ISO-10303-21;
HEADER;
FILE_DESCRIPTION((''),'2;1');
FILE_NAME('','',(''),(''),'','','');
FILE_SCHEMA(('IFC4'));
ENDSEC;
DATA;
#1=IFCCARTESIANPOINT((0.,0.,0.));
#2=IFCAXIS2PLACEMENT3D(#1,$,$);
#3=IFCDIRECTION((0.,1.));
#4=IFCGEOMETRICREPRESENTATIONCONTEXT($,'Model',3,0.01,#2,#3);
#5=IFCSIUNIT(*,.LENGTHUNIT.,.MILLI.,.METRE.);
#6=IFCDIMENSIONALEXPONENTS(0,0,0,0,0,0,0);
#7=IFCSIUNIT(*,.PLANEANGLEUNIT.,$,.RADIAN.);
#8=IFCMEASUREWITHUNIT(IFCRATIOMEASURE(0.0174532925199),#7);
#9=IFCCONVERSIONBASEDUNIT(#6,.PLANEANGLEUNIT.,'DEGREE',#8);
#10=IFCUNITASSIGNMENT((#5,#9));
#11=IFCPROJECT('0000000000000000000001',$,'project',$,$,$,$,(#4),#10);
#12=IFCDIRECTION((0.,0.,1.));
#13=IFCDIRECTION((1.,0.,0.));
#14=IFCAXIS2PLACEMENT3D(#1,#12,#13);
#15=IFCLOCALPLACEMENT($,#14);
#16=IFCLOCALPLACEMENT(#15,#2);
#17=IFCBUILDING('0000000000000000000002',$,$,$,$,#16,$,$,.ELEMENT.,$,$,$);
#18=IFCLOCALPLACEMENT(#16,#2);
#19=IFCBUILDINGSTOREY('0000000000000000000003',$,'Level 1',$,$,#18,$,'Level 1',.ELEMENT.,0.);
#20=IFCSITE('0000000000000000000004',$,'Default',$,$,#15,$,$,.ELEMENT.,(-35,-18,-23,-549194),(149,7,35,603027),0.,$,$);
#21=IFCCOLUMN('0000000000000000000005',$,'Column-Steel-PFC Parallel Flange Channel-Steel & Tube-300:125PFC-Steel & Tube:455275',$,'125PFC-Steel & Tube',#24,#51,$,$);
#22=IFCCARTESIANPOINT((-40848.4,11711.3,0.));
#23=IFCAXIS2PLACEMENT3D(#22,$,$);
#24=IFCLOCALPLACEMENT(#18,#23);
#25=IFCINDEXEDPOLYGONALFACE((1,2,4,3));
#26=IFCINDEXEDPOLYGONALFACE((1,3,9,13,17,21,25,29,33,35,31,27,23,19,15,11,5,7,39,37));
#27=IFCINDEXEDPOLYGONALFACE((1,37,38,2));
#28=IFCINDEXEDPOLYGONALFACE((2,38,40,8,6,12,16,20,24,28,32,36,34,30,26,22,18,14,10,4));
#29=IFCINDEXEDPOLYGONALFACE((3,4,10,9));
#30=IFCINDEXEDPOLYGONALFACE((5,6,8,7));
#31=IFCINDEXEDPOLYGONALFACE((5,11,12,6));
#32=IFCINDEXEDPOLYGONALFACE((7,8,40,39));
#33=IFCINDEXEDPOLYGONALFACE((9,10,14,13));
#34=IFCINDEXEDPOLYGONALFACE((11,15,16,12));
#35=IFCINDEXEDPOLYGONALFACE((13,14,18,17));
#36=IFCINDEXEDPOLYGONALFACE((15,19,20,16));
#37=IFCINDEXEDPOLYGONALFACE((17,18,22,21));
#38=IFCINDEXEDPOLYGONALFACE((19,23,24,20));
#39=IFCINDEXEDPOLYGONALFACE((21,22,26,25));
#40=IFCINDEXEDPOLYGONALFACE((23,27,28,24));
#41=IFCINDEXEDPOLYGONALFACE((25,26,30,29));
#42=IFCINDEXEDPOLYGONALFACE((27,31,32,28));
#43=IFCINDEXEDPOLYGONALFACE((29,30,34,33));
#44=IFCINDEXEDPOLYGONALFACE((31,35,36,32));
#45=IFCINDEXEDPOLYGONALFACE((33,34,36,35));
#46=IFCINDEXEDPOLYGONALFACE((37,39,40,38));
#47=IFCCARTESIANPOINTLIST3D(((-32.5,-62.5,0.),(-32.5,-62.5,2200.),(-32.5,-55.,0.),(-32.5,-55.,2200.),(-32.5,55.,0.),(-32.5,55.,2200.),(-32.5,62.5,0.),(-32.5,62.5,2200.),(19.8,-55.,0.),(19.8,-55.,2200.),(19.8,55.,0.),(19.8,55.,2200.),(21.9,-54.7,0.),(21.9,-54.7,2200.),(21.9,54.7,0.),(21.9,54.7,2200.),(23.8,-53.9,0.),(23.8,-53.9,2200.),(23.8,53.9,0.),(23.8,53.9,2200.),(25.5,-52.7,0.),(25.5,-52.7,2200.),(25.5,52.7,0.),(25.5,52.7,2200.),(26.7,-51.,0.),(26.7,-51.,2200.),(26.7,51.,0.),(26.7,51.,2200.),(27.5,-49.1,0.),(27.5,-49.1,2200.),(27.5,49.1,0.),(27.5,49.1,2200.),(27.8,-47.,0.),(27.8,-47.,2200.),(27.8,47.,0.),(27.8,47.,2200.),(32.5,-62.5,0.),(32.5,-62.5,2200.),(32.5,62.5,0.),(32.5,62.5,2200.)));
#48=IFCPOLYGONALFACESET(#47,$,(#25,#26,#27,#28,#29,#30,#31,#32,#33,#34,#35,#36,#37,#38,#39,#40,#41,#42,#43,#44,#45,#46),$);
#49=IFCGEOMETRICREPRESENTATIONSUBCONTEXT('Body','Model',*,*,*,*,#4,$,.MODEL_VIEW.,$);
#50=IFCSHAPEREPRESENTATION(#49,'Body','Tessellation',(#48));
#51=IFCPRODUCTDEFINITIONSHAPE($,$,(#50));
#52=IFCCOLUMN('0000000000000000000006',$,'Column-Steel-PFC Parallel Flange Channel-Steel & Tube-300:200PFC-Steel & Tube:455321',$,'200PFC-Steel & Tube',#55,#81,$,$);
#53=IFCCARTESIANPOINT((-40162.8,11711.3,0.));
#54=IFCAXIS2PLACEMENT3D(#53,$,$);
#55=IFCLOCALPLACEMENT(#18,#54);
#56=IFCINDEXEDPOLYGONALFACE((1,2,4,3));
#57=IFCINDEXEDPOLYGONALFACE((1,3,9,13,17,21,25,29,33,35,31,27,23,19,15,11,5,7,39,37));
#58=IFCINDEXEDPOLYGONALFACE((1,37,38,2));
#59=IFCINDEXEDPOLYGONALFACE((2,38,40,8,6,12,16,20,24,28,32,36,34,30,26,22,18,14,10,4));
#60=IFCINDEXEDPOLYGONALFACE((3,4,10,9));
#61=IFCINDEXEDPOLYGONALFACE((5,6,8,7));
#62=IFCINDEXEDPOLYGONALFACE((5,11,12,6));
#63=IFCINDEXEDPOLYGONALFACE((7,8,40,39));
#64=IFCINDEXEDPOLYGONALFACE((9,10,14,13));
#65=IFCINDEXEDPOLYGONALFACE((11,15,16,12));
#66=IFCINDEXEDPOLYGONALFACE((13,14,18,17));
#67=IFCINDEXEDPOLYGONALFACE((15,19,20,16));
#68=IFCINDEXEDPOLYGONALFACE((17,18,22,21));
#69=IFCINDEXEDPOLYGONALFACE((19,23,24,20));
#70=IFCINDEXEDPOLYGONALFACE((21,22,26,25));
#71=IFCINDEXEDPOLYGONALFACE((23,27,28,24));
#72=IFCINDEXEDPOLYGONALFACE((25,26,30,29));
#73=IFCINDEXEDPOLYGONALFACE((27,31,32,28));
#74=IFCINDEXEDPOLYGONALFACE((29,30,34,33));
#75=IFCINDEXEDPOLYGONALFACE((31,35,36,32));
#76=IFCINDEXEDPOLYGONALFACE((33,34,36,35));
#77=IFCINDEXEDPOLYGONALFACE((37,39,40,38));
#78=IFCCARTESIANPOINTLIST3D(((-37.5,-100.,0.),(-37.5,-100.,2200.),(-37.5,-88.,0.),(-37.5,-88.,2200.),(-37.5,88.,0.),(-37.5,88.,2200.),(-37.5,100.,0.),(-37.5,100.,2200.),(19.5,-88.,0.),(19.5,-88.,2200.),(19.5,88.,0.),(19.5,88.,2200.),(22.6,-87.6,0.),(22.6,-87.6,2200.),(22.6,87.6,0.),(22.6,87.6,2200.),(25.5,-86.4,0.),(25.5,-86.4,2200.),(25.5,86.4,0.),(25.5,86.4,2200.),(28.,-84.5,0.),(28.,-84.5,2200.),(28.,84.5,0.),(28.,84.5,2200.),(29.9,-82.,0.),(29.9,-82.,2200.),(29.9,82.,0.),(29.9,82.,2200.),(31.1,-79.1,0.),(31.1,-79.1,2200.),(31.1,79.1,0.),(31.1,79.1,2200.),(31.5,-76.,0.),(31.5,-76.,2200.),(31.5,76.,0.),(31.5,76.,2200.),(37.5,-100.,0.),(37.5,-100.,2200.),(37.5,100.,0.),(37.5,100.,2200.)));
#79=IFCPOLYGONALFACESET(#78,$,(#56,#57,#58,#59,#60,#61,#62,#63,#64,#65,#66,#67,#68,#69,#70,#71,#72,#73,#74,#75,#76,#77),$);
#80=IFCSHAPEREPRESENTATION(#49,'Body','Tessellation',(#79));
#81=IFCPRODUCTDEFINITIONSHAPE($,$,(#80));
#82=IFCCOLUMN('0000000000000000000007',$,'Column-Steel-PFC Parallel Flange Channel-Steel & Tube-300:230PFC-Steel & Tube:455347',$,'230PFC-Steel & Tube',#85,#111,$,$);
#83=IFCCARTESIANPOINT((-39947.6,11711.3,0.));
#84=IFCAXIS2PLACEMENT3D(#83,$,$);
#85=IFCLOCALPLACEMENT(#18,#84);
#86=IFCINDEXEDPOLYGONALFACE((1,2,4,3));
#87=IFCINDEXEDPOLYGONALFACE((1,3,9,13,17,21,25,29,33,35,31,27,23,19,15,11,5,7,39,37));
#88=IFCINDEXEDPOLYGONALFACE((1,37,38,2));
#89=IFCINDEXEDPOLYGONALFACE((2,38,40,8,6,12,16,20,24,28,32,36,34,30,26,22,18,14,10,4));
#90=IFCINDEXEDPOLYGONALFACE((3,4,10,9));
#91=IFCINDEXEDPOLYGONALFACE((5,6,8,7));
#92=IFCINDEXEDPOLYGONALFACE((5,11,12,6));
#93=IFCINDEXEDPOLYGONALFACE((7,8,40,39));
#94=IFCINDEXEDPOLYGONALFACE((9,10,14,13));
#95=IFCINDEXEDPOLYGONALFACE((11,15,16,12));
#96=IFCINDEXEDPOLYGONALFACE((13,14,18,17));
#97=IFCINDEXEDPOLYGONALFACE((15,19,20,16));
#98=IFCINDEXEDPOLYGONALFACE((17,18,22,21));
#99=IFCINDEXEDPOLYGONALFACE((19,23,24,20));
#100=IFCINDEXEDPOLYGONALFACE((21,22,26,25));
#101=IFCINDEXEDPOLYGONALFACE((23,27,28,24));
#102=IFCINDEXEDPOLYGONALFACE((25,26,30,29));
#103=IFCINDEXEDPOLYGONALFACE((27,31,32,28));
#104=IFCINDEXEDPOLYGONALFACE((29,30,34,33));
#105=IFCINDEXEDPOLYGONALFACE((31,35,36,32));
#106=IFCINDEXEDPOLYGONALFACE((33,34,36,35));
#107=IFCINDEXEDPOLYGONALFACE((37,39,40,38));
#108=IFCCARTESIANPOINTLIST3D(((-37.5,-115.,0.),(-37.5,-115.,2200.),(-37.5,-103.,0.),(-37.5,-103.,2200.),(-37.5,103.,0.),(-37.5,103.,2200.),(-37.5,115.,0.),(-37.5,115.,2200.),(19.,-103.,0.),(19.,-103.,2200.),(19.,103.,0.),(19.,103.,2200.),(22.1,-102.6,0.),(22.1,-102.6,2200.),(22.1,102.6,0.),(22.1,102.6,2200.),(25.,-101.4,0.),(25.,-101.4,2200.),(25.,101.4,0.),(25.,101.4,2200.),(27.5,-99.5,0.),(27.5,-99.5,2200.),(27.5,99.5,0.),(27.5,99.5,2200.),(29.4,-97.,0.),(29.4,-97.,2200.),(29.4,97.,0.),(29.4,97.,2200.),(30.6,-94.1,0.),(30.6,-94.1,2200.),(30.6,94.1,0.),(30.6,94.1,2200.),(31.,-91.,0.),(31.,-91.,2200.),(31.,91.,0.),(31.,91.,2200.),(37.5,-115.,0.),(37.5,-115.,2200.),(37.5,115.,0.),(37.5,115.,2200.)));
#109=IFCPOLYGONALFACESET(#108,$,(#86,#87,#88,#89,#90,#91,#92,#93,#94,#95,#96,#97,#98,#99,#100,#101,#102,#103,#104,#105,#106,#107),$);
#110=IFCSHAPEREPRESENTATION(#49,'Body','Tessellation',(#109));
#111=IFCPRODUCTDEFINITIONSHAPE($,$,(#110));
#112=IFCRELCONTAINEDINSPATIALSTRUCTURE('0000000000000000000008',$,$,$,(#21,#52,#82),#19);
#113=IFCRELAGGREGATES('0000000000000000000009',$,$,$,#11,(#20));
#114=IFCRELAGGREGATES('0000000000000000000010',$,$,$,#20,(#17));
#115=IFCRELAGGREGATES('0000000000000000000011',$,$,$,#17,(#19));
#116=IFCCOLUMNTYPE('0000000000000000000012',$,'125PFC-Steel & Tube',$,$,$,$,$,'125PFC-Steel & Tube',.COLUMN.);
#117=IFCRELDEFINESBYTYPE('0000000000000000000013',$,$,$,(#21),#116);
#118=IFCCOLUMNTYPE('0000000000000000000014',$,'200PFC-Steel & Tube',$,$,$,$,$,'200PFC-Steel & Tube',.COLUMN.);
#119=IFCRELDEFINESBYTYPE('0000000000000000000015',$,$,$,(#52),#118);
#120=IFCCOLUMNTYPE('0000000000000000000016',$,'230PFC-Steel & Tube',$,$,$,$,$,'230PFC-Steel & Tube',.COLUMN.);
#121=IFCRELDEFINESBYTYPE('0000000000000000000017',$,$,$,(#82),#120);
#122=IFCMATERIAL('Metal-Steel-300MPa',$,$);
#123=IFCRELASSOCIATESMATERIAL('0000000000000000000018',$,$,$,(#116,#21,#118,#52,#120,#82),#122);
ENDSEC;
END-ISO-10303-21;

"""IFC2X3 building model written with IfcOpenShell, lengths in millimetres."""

from ifc_helpers import new_model, entity, si_unit, converted_unit, direction, frame, frame_2d, origin, origin_with_axes, place, context, subcontext, project, spatial, polyline, circle_curve, parameter, trimmed, segment, composite_curve, outline, extrude, source, transform, mapped, material, type_object, type_shapes, element, save


model = new_model("IFC2X3")

# Units and contexts
model_context = context("Model", 3, precision=0.01, world=origin(), true_north=direction((0.0, 1.0)))
body_context = subcontext(model_context, "Body", "Model", "MODEL_VIEW")
ifc_project = project(units=[si_unit("LENGTHUNIT", "METRE", prefix="MILLI"), converted_unit("PLANEANGLEUNIT", "DEGREE", entity("IfcRatioMeasure", 0.0174532925199), si_unit("PLANEANGLEUNIT", "RADIAN"), dimensions=[0, 0, 0, 0, 0, 0, 0])], contexts=[model_context])

# Site, building, storey
site_placement = place(None, origin_with_axes())
site = spatial("IfcSite", under=ifc_project, at=site_placement, Name="Default", CompositionType="ELEMENT", RefLatitude=(-35, -18, -23, -549194), RefLongitude=(149, 7, 35, 603027), RefElevation=0.0)
building_placement = place(site_placement, origin())
building = spatial("IfcBuilding", under=site, at=building_placement, CompositionType="ELEMENT")
storey_placement = place(building_placement, origin())
storey = spatial("IfcBuildingStorey", under=building, at=storey_placement, Name="Level 1", LongName="Level 1", CompositionType="ELEMENT", Elevation=0.0)

# Columns
ifc_material = material(Name="Metal-Steel-300MPa")
column_type_1 = type_object("IfcColumnType", Name="125PFC-Steel & Tube", ElementType="125PFC-Steel & Tube", PredefinedType="COLUMN", material=ifc_material)
shared_shape_1 = source(origin(), body_context, "Body", "SweptSolid", [
    extrude(outline(composite_curve([segment(polyline([(55.0, -35.5), (62.5, -35.5)]), True, "CONTINUOUS"), segment(polyline([(62.5, -35.5), (62.5, 29.5)]), True, "CONTINUOUS"), segment(polyline([(62.5, 29.5), (-62.5, 29.5)]), True, "CONTINUOUS"), segment(polyline([(-62.5, 29.5), (-62.5, -35.5)]), True, "CONTINUOUS"), segment(polyline([(-62.5, -35.5), (-55.0, -35.5)]), True, "CONTINUOUS"), segment(polyline([(-55.0, -35.5), (-55.0, 16.8)]), True, "CONTINUOUS"), segment(trimmed(circle_curve(frame_2d((-47.0, 16.8), x_axis=(-1.0, 0.0)), 8.0), [parameter(270.0)], [parameter(0.0)], True, "PARAMETER"), False, "CONTINUOUS"), segment(polyline([(-47.0, 24.8), (47.0, 24.8)]), True, "CONTINUOUS"), segment(trimmed(circle_curve(frame_2d((47.0, 16.8), x_axis=(0.0, 1.0)), 8.0), [parameter(270.0)], [parameter(0.0)], True, "PARAMETER"), False, "CONTINUOUS"), segment(polyline([(55.0, 16.8), (55.0, -35.5)]), True, "CONTINUOUS")], self_intersect=False)), frame((3.0, 0.0, 0.0), z_axis=(0.0, 0.0, 1.0), x_axis=(0.0, -1.0, 0.0)), (0.0, 0.0, 1.0), 2200.0),
])
type_shapes(column_type_1, [shared_shape_1])
column_1_placement = place(storey_placement, frame((-40848.4, 11711.3, 0.0)))
element("IfcColumn", 1, at=column_1_placement, inside=storey, type_object=column_type_1, material=ifc_material, Name="Column-Steel-PFC Parallel Flange Channel-Steel & Tube-300:125PFC-Steel & Tube:455275", ObjectType="125PFC-Steel & Tube", context=body_context, shape_type="MappedRepresentation", body=[
    mapped(shared_shape_1, transform((0.0, 0.0, 0.0), scale=1.0)),
])
column_type_2 = type_object("IfcColumnType", Name="200PFC-Steel & Tube", ElementType="200PFC-Steel & Tube", PredefinedType="COLUMN", material=ifc_material)
shared_shape_2 = source(origin(), body_context, "Body", "SweptSolid", [
    extrude(outline(composite_curve([segment(polyline([(88.0, -40.2), (100.0, -40.2)]), True, "CONTINUOUS"), segment(polyline([(100.0, -40.2), (100.0, 34.8)]), True, "CONTINUOUS"), segment(polyline([(100.0, 34.8), (-100.0, 34.8)]), True, "CONTINUOUS"), segment(polyline([(-100.0, 34.8), (-100.0, -40.2)]), True, "CONTINUOUS"), segment(polyline([(-100.0, -40.2), (-88.0, -40.2)]), True, "CONTINUOUS"), segment(polyline([(-88.0, -40.2), (-88.0, 16.8)]), True, "CONTINUOUS"), segment(trimmed(circle_curve(frame_2d((-76.0, 16.8), x_axis=(-1.0, 0.0)), 12.0), [parameter(270.0)], [parameter(0.0)], True, "PARAMETER"), False, "CONTINUOUS"), segment(polyline([(-76.0, 28.8), (76.0, 28.8)]), True, "CONTINUOUS"), segment(trimmed(circle_curve(frame_2d((76.0, 16.8), x_axis=(0.0, 1.0)), 12.0), [parameter(270.0)], [parameter(0.0)], True, "PARAMETER"), False, "CONTINUOUS"), segment(polyline([(88.0, 16.8), (88.0, -40.2)]), True, "CONTINUOUS")], self_intersect=False)), frame((2.7, 0.0, 0.0), z_axis=(0.0, 0.0, 1.0), x_axis=(0.0, -1.0, 0.0)), (0.0, 0.0, 1.0), 2200.0),
])
type_shapes(column_type_2, [shared_shape_2])
column_2_placement = place(storey_placement, frame((-40162.8, 11711.3, 0.0)))
element("IfcColumn", 2, at=column_2_placement, inside=storey, type_object=column_type_2, material=ifc_material, Name="Column-Steel-PFC Parallel Flange Channel-Steel & Tube-300:200PFC-Steel & Tube:455321", ObjectType="200PFC-Steel & Tube", context=body_context, shape_type="MappedRepresentation", body=[
    mapped(shared_shape_2, transform((0.0, 0.0, 0.0), scale=1.0)),
])
column_type_3 = type_object("IfcColumnType", Name="230PFC-Steel & Tube", ElementType="230PFC-Steel & Tube", PredefinedType="COLUMN", material=ifc_material)
shared_shape_3 = source(origin(), body_context, "Body", "SweptSolid", [
    extrude(outline(composite_curve([segment(polyline([(103.0, -40.0), (115.0, -40.0)]), True, "CONTINUOUS"), segment(polyline([(115.0, -40.0), (115.0, 35.0)]), True, "CONTINUOUS"), segment(polyline([(115.0, 35.0), (-115.0, 35.0)]), True, "CONTINUOUS"), segment(polyline([(-115.0, 35.0), (-115.0, -40.0)]), True, "CONTINUOUS"), segment(polyline([(-115.0, -40.0), (-103.0, -40.0)]), True, "CONTINUOUS"), segment(polyline([(-103.0, -40.0), (-103.0, 16.5)]), True, "CONTINUOUS"), segment(trimmed(circle_curve(frame_2d((-91.0, 16.5), x_axis=(-1.0, 0.0)), 12.0), [parameter(270.0)], [parameter(0.0)], True, "PARAMETER"), False, "CONTINUOUS"), segment(polyline([(-91.0, 28.5), (91.0, 28.5)]), True, "CONTINUOUS"), segment(trimmed(circle_curve(frame_2d((91.0, 16.5), x_axis=(0.0, 1.0)), 12.0), [parameter(270.0)], [parameter(0.0)], True, "PARAMETER"), False, "CONTINUOUS"), segment(polyline([(103.0, 16.5), (103.0, -40.0)]), True, "CONTINUOUS")], self_intersect=False)), frame((2.5, 0.0, 0.0), z_axis=(0.0, 0.0, 1.0), x_axis=(0.0, -1.0, 0.0)), (0.0, 0.0, 1.0), 2200.0),
])
type_shapes(column_type_3, [shared_shape_3])
column_3_placement = place(storey_placement, frame((-39947.6, 11711.3, 0.0)))
element("IfcColumn", 3, at=column_3_placement, inside=storey, type_object=column_type_3, material=ifc_material, Name="Column-Steel-PFC Parallel Flange Channel-Steel & Tube-300:230PFC-Steel & Tube:455347", ObjectType="230PFC-Steel & Tube", context=body_context, shape_type="MappedRepresentation", body=[
    mapped(shared_shape_3, transform((0.0, 0.0, 0.0), scale=1.0)),
])

save(model, "model.ifc")
